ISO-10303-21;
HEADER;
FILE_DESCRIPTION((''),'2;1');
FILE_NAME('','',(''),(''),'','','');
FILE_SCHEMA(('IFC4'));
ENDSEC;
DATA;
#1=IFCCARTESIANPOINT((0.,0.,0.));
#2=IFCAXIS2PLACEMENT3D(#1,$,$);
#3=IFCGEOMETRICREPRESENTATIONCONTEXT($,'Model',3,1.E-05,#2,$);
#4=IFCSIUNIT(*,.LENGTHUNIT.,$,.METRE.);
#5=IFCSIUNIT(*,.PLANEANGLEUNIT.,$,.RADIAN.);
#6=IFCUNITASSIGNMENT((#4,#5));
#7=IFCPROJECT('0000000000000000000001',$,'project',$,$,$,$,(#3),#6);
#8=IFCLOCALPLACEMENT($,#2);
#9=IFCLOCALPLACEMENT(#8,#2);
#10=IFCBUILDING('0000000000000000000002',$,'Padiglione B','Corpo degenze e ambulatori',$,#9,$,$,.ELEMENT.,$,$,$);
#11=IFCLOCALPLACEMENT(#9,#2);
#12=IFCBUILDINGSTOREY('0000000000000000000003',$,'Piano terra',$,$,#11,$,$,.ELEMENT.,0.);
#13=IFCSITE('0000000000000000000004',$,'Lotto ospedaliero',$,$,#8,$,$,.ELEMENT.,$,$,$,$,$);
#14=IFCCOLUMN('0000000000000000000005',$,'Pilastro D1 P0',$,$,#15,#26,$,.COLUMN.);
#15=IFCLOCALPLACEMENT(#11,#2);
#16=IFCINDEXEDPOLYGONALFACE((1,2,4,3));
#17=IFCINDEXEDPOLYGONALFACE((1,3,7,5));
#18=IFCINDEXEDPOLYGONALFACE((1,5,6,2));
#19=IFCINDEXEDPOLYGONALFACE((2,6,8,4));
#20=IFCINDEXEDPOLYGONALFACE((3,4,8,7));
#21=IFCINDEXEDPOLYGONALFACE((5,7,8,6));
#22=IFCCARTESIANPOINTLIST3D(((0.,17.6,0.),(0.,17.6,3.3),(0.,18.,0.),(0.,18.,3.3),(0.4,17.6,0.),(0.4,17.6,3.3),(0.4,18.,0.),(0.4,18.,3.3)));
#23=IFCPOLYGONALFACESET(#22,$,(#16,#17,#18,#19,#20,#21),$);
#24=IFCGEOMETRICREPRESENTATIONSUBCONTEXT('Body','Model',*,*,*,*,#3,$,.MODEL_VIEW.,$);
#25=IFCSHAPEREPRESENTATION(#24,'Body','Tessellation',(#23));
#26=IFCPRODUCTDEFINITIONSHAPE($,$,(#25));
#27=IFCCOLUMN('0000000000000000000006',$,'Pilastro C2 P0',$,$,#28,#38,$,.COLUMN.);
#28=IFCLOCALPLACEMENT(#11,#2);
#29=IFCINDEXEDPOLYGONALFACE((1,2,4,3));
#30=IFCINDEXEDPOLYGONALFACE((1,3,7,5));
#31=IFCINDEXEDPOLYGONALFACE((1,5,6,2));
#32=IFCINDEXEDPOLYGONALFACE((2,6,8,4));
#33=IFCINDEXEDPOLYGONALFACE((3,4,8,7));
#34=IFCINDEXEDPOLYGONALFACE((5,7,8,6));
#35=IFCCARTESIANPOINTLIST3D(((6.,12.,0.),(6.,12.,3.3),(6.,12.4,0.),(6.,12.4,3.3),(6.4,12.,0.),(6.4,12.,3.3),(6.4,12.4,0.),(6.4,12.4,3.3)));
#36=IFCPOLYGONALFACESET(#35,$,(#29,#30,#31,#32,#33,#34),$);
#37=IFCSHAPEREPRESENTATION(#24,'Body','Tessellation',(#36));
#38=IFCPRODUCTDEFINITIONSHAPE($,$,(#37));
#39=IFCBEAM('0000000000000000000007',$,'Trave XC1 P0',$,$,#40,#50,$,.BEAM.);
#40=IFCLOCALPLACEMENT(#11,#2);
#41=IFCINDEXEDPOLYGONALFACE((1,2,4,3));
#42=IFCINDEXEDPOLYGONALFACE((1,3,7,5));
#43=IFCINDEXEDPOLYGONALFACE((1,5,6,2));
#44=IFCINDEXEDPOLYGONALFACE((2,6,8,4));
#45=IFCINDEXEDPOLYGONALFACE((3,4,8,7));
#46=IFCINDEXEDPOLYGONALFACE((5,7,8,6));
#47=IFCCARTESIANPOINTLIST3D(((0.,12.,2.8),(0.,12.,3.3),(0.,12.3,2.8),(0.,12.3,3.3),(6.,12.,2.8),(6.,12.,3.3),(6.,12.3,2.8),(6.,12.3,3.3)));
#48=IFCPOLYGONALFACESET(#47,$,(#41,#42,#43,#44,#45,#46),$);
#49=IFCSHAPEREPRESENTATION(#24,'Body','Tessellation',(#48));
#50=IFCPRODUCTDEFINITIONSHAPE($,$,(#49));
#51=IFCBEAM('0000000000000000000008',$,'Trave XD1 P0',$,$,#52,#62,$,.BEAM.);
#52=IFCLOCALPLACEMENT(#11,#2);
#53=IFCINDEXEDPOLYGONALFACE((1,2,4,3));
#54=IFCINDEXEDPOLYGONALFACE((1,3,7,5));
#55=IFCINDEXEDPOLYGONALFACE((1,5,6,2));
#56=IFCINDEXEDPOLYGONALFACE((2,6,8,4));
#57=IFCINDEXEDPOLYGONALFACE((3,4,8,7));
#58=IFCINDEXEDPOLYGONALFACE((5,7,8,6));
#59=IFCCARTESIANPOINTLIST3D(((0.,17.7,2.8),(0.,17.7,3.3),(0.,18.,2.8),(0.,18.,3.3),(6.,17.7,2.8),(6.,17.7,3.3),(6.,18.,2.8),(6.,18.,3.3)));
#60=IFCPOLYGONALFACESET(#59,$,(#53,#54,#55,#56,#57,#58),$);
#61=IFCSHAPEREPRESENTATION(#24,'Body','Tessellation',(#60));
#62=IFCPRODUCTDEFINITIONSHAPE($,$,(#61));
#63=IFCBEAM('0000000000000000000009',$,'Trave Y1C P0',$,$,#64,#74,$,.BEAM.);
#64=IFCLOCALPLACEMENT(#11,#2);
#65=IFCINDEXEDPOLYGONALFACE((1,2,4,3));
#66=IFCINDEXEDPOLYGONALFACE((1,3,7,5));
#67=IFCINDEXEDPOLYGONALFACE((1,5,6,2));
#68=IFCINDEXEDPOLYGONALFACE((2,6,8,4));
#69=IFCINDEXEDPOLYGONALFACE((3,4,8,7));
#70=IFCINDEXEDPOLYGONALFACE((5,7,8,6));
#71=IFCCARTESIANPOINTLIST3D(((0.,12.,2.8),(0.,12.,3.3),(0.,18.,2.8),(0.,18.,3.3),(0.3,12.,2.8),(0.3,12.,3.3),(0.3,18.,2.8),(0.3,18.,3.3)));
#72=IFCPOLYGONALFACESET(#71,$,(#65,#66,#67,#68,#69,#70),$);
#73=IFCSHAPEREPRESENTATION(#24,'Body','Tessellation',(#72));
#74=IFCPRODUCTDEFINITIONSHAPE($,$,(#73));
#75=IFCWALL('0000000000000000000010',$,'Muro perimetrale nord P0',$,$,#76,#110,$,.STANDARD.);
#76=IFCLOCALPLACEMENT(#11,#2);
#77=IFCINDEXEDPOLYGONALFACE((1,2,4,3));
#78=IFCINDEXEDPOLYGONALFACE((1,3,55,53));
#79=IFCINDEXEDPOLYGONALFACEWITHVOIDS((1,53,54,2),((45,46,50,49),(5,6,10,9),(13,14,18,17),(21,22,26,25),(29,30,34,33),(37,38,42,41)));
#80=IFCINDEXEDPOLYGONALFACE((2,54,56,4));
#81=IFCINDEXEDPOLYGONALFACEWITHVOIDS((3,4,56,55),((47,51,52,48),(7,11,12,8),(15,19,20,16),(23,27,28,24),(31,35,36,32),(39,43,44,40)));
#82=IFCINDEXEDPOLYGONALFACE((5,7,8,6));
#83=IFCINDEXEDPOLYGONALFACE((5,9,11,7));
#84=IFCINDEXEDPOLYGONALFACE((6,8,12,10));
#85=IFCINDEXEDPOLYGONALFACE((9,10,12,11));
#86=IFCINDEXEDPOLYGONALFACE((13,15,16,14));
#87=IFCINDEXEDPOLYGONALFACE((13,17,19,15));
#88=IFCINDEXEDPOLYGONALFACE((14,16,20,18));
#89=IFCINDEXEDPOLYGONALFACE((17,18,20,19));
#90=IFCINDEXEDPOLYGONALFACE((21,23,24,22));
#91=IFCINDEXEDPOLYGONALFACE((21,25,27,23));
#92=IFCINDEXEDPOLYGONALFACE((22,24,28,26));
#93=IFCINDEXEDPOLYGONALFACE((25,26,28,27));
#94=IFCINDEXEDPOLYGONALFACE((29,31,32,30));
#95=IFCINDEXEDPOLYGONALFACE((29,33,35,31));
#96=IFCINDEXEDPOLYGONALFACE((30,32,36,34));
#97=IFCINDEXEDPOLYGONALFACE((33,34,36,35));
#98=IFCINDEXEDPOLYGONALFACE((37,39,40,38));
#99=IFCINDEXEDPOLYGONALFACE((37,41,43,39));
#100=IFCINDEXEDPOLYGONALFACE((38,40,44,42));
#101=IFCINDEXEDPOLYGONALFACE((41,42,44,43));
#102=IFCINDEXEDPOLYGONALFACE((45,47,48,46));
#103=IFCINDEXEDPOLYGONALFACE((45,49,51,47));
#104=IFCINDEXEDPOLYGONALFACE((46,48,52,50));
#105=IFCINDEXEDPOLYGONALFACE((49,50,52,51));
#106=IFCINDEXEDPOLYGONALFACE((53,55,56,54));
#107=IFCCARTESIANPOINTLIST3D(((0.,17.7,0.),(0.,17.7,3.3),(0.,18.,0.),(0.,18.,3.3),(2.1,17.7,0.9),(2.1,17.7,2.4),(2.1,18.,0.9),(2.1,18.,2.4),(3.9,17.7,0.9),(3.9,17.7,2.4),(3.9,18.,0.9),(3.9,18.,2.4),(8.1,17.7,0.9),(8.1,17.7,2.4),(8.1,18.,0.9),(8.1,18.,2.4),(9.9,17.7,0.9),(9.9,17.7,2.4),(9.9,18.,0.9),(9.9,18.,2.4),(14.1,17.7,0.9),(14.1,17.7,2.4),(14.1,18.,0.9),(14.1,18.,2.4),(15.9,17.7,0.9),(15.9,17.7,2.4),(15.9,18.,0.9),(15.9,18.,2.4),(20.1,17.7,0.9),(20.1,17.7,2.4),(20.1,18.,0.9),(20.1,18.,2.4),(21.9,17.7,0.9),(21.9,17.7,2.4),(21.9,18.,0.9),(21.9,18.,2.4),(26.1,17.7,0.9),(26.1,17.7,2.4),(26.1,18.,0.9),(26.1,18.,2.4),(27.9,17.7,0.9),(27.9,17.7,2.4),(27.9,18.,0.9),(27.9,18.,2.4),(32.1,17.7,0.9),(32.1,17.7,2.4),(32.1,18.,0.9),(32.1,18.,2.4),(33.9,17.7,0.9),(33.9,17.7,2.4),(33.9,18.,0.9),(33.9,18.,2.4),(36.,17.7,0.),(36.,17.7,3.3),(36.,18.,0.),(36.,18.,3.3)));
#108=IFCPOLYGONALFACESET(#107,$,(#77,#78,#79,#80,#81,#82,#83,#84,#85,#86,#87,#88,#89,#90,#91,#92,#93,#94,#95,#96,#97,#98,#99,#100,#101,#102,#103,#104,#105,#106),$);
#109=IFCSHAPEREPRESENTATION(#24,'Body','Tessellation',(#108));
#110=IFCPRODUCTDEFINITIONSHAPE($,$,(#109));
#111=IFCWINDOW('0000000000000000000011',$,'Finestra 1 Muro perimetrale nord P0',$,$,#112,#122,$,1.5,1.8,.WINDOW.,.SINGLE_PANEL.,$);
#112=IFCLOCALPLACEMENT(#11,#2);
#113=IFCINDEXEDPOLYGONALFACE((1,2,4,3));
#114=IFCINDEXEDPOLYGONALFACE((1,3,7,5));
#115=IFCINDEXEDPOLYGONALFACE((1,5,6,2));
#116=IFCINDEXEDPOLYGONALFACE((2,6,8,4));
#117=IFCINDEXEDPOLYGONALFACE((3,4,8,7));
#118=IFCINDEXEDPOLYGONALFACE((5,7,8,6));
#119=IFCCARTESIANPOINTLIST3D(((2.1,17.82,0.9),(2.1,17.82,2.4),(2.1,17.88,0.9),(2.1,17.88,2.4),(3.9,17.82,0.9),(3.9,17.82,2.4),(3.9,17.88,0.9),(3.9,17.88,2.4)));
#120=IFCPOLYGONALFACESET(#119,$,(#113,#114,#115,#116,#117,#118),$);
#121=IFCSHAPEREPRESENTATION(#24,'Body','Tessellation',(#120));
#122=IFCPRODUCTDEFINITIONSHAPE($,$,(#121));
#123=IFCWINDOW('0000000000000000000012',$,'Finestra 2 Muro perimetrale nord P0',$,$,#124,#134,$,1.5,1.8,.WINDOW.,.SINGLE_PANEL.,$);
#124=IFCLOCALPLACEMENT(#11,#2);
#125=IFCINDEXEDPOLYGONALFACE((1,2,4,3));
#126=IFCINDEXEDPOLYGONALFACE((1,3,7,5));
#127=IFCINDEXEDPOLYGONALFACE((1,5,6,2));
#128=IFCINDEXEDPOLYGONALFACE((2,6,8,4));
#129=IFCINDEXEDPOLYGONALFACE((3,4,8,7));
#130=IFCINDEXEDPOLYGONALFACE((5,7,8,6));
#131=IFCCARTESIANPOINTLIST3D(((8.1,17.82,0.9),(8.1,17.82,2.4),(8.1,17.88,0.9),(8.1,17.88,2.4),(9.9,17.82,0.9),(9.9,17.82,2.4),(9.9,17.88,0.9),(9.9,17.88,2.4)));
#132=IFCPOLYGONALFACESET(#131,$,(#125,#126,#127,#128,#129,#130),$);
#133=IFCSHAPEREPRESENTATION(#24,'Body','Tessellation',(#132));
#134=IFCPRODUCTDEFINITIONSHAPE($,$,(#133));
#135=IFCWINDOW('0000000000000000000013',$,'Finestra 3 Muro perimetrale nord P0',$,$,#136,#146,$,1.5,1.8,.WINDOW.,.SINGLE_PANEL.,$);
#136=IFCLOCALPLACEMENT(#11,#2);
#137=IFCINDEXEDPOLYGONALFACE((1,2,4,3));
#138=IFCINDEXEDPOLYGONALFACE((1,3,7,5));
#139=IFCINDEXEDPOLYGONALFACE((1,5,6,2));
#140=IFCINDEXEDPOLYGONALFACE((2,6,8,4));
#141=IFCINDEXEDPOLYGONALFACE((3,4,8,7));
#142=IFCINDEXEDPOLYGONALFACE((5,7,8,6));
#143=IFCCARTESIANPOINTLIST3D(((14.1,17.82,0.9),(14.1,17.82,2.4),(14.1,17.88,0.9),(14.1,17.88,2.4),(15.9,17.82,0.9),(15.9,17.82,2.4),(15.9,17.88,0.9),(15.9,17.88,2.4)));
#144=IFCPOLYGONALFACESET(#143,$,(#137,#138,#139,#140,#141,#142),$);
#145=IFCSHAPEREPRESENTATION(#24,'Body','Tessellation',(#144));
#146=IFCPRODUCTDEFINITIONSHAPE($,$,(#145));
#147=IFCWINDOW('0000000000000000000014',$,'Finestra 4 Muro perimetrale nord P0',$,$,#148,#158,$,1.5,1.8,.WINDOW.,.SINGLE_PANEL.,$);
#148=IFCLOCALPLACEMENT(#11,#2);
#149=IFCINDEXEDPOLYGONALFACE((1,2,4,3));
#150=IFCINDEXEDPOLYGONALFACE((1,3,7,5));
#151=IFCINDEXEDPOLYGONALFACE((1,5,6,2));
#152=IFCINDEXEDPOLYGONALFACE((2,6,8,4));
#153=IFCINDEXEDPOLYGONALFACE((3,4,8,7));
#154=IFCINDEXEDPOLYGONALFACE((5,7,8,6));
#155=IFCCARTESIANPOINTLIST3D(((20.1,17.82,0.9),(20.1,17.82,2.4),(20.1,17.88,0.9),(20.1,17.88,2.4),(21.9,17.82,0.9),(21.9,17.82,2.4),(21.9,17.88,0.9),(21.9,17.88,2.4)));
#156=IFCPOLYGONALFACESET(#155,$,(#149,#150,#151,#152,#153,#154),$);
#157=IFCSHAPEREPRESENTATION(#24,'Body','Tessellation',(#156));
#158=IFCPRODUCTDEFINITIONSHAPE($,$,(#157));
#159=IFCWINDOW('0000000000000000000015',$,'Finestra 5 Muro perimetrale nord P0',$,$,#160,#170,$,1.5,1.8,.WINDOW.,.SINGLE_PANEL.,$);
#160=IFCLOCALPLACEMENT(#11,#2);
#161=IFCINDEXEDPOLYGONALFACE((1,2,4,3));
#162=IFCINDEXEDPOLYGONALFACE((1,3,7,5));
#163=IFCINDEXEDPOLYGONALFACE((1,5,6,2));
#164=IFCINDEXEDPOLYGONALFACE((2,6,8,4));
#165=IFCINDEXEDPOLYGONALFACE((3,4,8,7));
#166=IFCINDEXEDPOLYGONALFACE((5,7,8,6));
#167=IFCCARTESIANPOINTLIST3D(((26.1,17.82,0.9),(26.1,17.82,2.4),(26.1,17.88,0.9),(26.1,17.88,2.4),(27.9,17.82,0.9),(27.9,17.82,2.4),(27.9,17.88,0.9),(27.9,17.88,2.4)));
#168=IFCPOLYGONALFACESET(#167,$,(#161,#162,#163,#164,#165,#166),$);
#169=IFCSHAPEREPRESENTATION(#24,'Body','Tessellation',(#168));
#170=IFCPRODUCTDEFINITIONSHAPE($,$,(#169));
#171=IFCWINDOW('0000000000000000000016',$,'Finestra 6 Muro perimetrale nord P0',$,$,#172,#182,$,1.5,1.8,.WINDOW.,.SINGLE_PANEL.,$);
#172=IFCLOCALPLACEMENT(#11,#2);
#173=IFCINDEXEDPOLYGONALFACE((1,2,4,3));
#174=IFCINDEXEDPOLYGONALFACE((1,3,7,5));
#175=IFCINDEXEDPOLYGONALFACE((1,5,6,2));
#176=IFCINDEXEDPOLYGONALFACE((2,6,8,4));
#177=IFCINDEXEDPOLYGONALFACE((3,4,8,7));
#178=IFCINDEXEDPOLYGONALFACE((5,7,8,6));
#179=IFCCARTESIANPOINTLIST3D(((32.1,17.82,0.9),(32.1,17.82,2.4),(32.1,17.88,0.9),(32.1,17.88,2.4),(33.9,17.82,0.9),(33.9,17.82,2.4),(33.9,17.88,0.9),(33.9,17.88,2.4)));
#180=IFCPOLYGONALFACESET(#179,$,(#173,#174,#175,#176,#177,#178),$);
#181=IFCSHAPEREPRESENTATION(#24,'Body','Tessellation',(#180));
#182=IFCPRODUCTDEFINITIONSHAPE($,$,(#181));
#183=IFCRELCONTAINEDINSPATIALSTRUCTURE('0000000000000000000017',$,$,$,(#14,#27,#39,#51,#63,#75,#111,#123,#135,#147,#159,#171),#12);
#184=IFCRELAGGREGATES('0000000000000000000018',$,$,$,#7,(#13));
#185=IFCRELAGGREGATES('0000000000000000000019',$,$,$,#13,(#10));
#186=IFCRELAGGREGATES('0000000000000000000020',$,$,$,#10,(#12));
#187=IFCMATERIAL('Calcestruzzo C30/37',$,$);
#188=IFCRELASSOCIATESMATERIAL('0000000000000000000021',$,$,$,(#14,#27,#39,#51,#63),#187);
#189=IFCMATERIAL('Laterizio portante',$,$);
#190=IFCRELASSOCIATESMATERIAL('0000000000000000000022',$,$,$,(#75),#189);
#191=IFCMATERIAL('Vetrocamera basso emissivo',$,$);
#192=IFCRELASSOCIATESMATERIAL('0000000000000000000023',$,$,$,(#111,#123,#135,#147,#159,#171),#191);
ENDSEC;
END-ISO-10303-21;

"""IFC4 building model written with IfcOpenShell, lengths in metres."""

from ifc_helpers import new_model, si_unit, frame, frame_2d, origin, place, context, subcontext, project, spatial, rectangle, extrude, material, element, fill, save


model = new_model("IFC4")

# Units and contexts
model_context = context("Model", 3, precision=1e-05, world=origin())
body_context = subcontext(model_context, "Body", "Model", "MODEL_VIEW")
ifc_project = project(units=[si_unit("LENGTHUNIT", "METRE"), si_unit("PLANEANGLEUNIT", "RADIAN")], contexts=[model_context])

# Site, building, storey
site_placement = place(None, origin())
site = spatial("IfcSite", under=ifc_project, at=site_placement, Name="Lotto ospedaliero", CompositionType="ELEMENT")
building_placement = place(site_placement, origin())
building = spatial("IfcBuilding", under=site, at=building_placement, Name="Padiglione B", Description="Corpo degenze e ambulatori", CompositionType="ELEMENT")
storey_placement = place(building_placement, origin())
storey = spatial("IfcBuildingStorey", under=building, at=storey_placement, Name="Piano terra", CompositionType="ELEMENT", Elevation=0.0)

# Columns
ifc_material_1 = material(Name="Calcestruzzo C30/37")
for number, where, name in (
    (1, (0.0, 17.6, 0.0), "Pilastro D1 P0"),
    (2, (6.0, 12.0, 0.0), "Pilastro C2 P0"),
):
    element("IfcColumn", number, at=place(storey_placement, frame(where)), inside=storey, material=ifc_material_1, Name=name, PredefinedType="COLUMN", context=body_context, shape_type="SweptSolid", body=[
        extrude(rectangle(XDim=0.4, YDim=0.4, at=frame_2d((0.2, 0.2))), origin(), (0.0, 0.0, 1.0), 3.3),
    ])

# Beams
for number, where, name in (
    (3, (0.0, 12.0, 2.8), "Trave XC1 P0"),
    (4, (0.0, 17.7, 2.8), "Trave XD1 P0"),
):
    element("IfcBeam", number, at=place(storey_placement, frame(where)), inside=storey, material=ifc_material_1, Name=name, PredefinedType="BEAM", context=body_context, shape_type="SweptSolid", body=[
        extrude(rectangle(XDim=6.0, YDim=0.3, at=frame_2d((3.0, 0.15))), origin(), (0.0, 0.0, 1.0), 0.5),
    ])
beam_placement = place(storey_placement, frame((0.0, 12.0, 2.8)))
element("IfcBeam", 5, at=beam_placement, inside=storey, material=ifc_material_1, Name="Trave Y1C P0", PredefinedType="BEAM", context=body_context, shape_type="SweptSolid", body=[
    extrude(rectangle(XDim=0.3, YDim=6.0, at=frame_2d((0.15, 3.0))), origin(), (0.0, 0.0, 1.0), 0.5),
])

# Wall, openings, windows
ifc_material_2 = material(Name="Laterizio portante")
wall_placement = place(storey_placement, frame((0.0, 17.7, 0.0)))
wall = element("IfcWall", 6, at=wall_placement, inside=storey, material=ifc_material_2, Name="Muro perimetrale nord P0", PredefinedType="STANDARD", context=body_context, shape_type="SweptSolid", body=[
    extrude(rectangle(XDim=36.0, YDim=0.3, at=frame_2d((18.0, 0.15))), origin(), (0.0, 0.0, 1.0), 3.3),
])
opening_1_placement = place(wall_placement, frame((2.1, -0.1, 0.9)))
opening_1 = element("IfcOpeningElement", 7, at=opening_1_placement, cuts=wall, PredefinedType="OPENING", context=body_context, shape_type="SweptSolid", body=[
    extrude(rectangle(XDim=1.8, YDim=0.5, at=frame_2d((0.9, 0.25))), origin(), (0.0, 0.0, 1.0), 1.5),
])
opening_2_placement = place(wall_placement, frame((8.1, -0.1, 0.9)))
opening_2 = element("IfcOpeningElement", 8, at=opening_2_placement, cuts=wall, PredefinedType="OPENING", context=body_context, shape_type="SweptSolid", body=[
    extrude(rectangle(XDim=1.8, YDim=0.5, at=frame_2d((0.9, 0.25))), origin(), (0.0, 0.0, 1.0), 1.5),
])
opening_3_placement = place(wall_placement, frame((14.1, -0.1, 0.9)))
opening_3 = element("IfcOpeningElement", 9, at=opening_3_placement, cuts=wall, PredefinedType="OPENING", context=body_context, shape_type="SweptSolid", body=[
    extrude(rectangle(XDim=1.8, YDim=0.5, at=frame_2d((0.9, 0.25))), origin(), (0.0, 0.0, 1.0), 1.5),
])
opening_4_placement = place(wall_placement, frame((20.1, -0.1, 0.9)))
opening_4 = element("IfcOpeningElement", 10, at=opening_4_placement, cuts=wall, PredefinedType="OPENING", context=body_context, shape_type="SweptSolid", body=[
    extrude(rectangle(XDim=1.8, YDim=0.5, at=frame_2d((0.9, 0.25))), origin(), (0.0, 0.0, 1.0), 1.5),
])
opening_5_placement = place(wall_placement, frame((26.1, -0.1, 0.9)))
opening_5 = element("IfcOpeningElement", 11, at=opening_5_placement, cuts=wall, PredefinedType="OPENING", context=body_context, shape_type="SweptSolid", body=[
    extrude(rectangle(XDim=1.8, YDim=0.5, at=frame_2d((0.9, 0.25))), origin(), (0.0, 0.0, 1.0), 1.5),
])
opening_6_placement = place(wall_placement, frame((32.1, -0.1, 0.9)))
opening_6 = element("IfcOpeningElement", 12, at=opening_6_placement, cuts=wall, PredefinedType="OPENING", context=body_context, shape_type="SweptSolid", body=[
    extrude(rectangle(XDim=1.8, YDim=0.5, at=frame_2d((0.9, 0.25))), origin(), (0.0, 0.0, 1.0), 1.5),
])
ifc_material_3 = material(Name="Vetrocamera basso emissivo")
window_1_placement = place(wall_placement, frame((2.1, 0.12, 0.9)))
window_1 = element("IfcWindow", 13, at=window_1_placement, inside=storey, material=ifc_material_3, Name="Finestra 1 Muro perimetrale nord P0", OverallHeight=1.5, OverallWidth=1.8, PartitioningType="SINGLE_PANEL", PredefinedType="WINDOW", context=body_context, shape_type="SweptSolid", body=[
    extrude(rectangle(XDim=1.8, YDim=0.06, at=frame_2d((0.9, 0.03))), origin(), (0.0, 0.0, 1.0), 1.5),
])
fill(opening_1, window_1)
window_2_placement = place(wall_placement, frame((8.1, 0.12, 0.9)))
window_2 = element("IfcWindow", 14, at=window_2_placement, inside=storey, material=ifc_material_3, Name="Finestra 2 Muro perimetrale nord P0", OverallHeight=1.5, OverallWidth=1.8, PartitioningType="SINGLE_PANEL", PredefinedType="WINDOW", context=body_context, shape_type="SweptSolid", body=[
    extrude(rectangle(XDim=1.8, YDim=0.06, at=frame_2d((0.9, 0.03))), origin(), (0.0, 0.0, 1.0), 1.5),
])
fill(opening_2, window_2)
window_3_placement = place(wall_placement, frame((14.1, 0.12, 0.9)))
window_3 = element("IfcWindow", 15, at=window_3_placement, inside=storey, material=ifc_material_3, Name="Finestra 3 Muro perimetrale nord P0", OverallHeight=1.5, OverallWidth=1.8, PartitioningType="SINGLE_PANEL", PredefinedType="WINDOW", context=body_context, shape_type="SweptSolid", body=[
    extrude(rectangle(XDim=1.8, YDim=0.06, at=frame_2d((0.9, 0.03))), origin(), (0.0, 0.0, 1.0), 1.5),
])
fill(opening_3, window_3)
window_4_placement = place(wall_placement, frame((20.1, 0.12, 0.9)))
window_4 = element("IfcWindow", 16, at=window_4_placement, inside=storey, material=ifc_material_3, Name="Finestra 4 Muro perimetrale nord P0", OverallHeight=1.5, OverallWidth=1.8, PartitioningType="SINGLE_PANEL", PredefinedType="WINDOW", context=body_context, shape_type="SweptSolid", body=[
    extrude(rectangle(XDim=1.8, YDim=0.06, at=frame_2d((0.9, 0.03))), origin(), (0.0, 0.0, 1.0), 1.5),
])
fill(opening_4, window_4)
window_5_placement = place(wall_placement, frame((26.1, 0.12, 0.9)))
window_5 = element("IfcWindow", 17, at=window_5_placement, inside=storey, material=ifc_material_3, Name="Finestra 5 Muro perimetrale nord P0", OverallHeight=1.5, OverallWidth=1.8, PartitioningType="SINGLE_PANEL", PredefinedType="WINDOW", context=body_context, shape_type="SweptSolid", body=[
    extrude(rectangle(XDim=1.8, YDim=0.06, at=frame_2d((0.9, 0.03))), origin(), (0.0, 0.0, 1.0), 1.5),
])
fill(opening_5, window_5)
window_6_placement = place(wall_placement, frame((32.1, 0.12, 0.9)))
window_6 = element("IfcWindow", 18, at=window_6_placement, inside=storey, material=ifc_material_3, Name="Finestra 6 Muro perimetrale nord P0", OverallHeight=1.5, OverallWidth=1.8, PartitioningType="SINGLE_PANEL", PredefinedType="WINDOW", context=body_context, shape_type="SweptSolid", body=[
    extrude(rectangle(XDim=1.8, YDim=0.06, at=frame_2d((0.9, 0.03))), origin(), (0.0, 0.0, 1.0), 1.5),
])
fill(opening_6, window_6)

save(model, "model.ifc")
